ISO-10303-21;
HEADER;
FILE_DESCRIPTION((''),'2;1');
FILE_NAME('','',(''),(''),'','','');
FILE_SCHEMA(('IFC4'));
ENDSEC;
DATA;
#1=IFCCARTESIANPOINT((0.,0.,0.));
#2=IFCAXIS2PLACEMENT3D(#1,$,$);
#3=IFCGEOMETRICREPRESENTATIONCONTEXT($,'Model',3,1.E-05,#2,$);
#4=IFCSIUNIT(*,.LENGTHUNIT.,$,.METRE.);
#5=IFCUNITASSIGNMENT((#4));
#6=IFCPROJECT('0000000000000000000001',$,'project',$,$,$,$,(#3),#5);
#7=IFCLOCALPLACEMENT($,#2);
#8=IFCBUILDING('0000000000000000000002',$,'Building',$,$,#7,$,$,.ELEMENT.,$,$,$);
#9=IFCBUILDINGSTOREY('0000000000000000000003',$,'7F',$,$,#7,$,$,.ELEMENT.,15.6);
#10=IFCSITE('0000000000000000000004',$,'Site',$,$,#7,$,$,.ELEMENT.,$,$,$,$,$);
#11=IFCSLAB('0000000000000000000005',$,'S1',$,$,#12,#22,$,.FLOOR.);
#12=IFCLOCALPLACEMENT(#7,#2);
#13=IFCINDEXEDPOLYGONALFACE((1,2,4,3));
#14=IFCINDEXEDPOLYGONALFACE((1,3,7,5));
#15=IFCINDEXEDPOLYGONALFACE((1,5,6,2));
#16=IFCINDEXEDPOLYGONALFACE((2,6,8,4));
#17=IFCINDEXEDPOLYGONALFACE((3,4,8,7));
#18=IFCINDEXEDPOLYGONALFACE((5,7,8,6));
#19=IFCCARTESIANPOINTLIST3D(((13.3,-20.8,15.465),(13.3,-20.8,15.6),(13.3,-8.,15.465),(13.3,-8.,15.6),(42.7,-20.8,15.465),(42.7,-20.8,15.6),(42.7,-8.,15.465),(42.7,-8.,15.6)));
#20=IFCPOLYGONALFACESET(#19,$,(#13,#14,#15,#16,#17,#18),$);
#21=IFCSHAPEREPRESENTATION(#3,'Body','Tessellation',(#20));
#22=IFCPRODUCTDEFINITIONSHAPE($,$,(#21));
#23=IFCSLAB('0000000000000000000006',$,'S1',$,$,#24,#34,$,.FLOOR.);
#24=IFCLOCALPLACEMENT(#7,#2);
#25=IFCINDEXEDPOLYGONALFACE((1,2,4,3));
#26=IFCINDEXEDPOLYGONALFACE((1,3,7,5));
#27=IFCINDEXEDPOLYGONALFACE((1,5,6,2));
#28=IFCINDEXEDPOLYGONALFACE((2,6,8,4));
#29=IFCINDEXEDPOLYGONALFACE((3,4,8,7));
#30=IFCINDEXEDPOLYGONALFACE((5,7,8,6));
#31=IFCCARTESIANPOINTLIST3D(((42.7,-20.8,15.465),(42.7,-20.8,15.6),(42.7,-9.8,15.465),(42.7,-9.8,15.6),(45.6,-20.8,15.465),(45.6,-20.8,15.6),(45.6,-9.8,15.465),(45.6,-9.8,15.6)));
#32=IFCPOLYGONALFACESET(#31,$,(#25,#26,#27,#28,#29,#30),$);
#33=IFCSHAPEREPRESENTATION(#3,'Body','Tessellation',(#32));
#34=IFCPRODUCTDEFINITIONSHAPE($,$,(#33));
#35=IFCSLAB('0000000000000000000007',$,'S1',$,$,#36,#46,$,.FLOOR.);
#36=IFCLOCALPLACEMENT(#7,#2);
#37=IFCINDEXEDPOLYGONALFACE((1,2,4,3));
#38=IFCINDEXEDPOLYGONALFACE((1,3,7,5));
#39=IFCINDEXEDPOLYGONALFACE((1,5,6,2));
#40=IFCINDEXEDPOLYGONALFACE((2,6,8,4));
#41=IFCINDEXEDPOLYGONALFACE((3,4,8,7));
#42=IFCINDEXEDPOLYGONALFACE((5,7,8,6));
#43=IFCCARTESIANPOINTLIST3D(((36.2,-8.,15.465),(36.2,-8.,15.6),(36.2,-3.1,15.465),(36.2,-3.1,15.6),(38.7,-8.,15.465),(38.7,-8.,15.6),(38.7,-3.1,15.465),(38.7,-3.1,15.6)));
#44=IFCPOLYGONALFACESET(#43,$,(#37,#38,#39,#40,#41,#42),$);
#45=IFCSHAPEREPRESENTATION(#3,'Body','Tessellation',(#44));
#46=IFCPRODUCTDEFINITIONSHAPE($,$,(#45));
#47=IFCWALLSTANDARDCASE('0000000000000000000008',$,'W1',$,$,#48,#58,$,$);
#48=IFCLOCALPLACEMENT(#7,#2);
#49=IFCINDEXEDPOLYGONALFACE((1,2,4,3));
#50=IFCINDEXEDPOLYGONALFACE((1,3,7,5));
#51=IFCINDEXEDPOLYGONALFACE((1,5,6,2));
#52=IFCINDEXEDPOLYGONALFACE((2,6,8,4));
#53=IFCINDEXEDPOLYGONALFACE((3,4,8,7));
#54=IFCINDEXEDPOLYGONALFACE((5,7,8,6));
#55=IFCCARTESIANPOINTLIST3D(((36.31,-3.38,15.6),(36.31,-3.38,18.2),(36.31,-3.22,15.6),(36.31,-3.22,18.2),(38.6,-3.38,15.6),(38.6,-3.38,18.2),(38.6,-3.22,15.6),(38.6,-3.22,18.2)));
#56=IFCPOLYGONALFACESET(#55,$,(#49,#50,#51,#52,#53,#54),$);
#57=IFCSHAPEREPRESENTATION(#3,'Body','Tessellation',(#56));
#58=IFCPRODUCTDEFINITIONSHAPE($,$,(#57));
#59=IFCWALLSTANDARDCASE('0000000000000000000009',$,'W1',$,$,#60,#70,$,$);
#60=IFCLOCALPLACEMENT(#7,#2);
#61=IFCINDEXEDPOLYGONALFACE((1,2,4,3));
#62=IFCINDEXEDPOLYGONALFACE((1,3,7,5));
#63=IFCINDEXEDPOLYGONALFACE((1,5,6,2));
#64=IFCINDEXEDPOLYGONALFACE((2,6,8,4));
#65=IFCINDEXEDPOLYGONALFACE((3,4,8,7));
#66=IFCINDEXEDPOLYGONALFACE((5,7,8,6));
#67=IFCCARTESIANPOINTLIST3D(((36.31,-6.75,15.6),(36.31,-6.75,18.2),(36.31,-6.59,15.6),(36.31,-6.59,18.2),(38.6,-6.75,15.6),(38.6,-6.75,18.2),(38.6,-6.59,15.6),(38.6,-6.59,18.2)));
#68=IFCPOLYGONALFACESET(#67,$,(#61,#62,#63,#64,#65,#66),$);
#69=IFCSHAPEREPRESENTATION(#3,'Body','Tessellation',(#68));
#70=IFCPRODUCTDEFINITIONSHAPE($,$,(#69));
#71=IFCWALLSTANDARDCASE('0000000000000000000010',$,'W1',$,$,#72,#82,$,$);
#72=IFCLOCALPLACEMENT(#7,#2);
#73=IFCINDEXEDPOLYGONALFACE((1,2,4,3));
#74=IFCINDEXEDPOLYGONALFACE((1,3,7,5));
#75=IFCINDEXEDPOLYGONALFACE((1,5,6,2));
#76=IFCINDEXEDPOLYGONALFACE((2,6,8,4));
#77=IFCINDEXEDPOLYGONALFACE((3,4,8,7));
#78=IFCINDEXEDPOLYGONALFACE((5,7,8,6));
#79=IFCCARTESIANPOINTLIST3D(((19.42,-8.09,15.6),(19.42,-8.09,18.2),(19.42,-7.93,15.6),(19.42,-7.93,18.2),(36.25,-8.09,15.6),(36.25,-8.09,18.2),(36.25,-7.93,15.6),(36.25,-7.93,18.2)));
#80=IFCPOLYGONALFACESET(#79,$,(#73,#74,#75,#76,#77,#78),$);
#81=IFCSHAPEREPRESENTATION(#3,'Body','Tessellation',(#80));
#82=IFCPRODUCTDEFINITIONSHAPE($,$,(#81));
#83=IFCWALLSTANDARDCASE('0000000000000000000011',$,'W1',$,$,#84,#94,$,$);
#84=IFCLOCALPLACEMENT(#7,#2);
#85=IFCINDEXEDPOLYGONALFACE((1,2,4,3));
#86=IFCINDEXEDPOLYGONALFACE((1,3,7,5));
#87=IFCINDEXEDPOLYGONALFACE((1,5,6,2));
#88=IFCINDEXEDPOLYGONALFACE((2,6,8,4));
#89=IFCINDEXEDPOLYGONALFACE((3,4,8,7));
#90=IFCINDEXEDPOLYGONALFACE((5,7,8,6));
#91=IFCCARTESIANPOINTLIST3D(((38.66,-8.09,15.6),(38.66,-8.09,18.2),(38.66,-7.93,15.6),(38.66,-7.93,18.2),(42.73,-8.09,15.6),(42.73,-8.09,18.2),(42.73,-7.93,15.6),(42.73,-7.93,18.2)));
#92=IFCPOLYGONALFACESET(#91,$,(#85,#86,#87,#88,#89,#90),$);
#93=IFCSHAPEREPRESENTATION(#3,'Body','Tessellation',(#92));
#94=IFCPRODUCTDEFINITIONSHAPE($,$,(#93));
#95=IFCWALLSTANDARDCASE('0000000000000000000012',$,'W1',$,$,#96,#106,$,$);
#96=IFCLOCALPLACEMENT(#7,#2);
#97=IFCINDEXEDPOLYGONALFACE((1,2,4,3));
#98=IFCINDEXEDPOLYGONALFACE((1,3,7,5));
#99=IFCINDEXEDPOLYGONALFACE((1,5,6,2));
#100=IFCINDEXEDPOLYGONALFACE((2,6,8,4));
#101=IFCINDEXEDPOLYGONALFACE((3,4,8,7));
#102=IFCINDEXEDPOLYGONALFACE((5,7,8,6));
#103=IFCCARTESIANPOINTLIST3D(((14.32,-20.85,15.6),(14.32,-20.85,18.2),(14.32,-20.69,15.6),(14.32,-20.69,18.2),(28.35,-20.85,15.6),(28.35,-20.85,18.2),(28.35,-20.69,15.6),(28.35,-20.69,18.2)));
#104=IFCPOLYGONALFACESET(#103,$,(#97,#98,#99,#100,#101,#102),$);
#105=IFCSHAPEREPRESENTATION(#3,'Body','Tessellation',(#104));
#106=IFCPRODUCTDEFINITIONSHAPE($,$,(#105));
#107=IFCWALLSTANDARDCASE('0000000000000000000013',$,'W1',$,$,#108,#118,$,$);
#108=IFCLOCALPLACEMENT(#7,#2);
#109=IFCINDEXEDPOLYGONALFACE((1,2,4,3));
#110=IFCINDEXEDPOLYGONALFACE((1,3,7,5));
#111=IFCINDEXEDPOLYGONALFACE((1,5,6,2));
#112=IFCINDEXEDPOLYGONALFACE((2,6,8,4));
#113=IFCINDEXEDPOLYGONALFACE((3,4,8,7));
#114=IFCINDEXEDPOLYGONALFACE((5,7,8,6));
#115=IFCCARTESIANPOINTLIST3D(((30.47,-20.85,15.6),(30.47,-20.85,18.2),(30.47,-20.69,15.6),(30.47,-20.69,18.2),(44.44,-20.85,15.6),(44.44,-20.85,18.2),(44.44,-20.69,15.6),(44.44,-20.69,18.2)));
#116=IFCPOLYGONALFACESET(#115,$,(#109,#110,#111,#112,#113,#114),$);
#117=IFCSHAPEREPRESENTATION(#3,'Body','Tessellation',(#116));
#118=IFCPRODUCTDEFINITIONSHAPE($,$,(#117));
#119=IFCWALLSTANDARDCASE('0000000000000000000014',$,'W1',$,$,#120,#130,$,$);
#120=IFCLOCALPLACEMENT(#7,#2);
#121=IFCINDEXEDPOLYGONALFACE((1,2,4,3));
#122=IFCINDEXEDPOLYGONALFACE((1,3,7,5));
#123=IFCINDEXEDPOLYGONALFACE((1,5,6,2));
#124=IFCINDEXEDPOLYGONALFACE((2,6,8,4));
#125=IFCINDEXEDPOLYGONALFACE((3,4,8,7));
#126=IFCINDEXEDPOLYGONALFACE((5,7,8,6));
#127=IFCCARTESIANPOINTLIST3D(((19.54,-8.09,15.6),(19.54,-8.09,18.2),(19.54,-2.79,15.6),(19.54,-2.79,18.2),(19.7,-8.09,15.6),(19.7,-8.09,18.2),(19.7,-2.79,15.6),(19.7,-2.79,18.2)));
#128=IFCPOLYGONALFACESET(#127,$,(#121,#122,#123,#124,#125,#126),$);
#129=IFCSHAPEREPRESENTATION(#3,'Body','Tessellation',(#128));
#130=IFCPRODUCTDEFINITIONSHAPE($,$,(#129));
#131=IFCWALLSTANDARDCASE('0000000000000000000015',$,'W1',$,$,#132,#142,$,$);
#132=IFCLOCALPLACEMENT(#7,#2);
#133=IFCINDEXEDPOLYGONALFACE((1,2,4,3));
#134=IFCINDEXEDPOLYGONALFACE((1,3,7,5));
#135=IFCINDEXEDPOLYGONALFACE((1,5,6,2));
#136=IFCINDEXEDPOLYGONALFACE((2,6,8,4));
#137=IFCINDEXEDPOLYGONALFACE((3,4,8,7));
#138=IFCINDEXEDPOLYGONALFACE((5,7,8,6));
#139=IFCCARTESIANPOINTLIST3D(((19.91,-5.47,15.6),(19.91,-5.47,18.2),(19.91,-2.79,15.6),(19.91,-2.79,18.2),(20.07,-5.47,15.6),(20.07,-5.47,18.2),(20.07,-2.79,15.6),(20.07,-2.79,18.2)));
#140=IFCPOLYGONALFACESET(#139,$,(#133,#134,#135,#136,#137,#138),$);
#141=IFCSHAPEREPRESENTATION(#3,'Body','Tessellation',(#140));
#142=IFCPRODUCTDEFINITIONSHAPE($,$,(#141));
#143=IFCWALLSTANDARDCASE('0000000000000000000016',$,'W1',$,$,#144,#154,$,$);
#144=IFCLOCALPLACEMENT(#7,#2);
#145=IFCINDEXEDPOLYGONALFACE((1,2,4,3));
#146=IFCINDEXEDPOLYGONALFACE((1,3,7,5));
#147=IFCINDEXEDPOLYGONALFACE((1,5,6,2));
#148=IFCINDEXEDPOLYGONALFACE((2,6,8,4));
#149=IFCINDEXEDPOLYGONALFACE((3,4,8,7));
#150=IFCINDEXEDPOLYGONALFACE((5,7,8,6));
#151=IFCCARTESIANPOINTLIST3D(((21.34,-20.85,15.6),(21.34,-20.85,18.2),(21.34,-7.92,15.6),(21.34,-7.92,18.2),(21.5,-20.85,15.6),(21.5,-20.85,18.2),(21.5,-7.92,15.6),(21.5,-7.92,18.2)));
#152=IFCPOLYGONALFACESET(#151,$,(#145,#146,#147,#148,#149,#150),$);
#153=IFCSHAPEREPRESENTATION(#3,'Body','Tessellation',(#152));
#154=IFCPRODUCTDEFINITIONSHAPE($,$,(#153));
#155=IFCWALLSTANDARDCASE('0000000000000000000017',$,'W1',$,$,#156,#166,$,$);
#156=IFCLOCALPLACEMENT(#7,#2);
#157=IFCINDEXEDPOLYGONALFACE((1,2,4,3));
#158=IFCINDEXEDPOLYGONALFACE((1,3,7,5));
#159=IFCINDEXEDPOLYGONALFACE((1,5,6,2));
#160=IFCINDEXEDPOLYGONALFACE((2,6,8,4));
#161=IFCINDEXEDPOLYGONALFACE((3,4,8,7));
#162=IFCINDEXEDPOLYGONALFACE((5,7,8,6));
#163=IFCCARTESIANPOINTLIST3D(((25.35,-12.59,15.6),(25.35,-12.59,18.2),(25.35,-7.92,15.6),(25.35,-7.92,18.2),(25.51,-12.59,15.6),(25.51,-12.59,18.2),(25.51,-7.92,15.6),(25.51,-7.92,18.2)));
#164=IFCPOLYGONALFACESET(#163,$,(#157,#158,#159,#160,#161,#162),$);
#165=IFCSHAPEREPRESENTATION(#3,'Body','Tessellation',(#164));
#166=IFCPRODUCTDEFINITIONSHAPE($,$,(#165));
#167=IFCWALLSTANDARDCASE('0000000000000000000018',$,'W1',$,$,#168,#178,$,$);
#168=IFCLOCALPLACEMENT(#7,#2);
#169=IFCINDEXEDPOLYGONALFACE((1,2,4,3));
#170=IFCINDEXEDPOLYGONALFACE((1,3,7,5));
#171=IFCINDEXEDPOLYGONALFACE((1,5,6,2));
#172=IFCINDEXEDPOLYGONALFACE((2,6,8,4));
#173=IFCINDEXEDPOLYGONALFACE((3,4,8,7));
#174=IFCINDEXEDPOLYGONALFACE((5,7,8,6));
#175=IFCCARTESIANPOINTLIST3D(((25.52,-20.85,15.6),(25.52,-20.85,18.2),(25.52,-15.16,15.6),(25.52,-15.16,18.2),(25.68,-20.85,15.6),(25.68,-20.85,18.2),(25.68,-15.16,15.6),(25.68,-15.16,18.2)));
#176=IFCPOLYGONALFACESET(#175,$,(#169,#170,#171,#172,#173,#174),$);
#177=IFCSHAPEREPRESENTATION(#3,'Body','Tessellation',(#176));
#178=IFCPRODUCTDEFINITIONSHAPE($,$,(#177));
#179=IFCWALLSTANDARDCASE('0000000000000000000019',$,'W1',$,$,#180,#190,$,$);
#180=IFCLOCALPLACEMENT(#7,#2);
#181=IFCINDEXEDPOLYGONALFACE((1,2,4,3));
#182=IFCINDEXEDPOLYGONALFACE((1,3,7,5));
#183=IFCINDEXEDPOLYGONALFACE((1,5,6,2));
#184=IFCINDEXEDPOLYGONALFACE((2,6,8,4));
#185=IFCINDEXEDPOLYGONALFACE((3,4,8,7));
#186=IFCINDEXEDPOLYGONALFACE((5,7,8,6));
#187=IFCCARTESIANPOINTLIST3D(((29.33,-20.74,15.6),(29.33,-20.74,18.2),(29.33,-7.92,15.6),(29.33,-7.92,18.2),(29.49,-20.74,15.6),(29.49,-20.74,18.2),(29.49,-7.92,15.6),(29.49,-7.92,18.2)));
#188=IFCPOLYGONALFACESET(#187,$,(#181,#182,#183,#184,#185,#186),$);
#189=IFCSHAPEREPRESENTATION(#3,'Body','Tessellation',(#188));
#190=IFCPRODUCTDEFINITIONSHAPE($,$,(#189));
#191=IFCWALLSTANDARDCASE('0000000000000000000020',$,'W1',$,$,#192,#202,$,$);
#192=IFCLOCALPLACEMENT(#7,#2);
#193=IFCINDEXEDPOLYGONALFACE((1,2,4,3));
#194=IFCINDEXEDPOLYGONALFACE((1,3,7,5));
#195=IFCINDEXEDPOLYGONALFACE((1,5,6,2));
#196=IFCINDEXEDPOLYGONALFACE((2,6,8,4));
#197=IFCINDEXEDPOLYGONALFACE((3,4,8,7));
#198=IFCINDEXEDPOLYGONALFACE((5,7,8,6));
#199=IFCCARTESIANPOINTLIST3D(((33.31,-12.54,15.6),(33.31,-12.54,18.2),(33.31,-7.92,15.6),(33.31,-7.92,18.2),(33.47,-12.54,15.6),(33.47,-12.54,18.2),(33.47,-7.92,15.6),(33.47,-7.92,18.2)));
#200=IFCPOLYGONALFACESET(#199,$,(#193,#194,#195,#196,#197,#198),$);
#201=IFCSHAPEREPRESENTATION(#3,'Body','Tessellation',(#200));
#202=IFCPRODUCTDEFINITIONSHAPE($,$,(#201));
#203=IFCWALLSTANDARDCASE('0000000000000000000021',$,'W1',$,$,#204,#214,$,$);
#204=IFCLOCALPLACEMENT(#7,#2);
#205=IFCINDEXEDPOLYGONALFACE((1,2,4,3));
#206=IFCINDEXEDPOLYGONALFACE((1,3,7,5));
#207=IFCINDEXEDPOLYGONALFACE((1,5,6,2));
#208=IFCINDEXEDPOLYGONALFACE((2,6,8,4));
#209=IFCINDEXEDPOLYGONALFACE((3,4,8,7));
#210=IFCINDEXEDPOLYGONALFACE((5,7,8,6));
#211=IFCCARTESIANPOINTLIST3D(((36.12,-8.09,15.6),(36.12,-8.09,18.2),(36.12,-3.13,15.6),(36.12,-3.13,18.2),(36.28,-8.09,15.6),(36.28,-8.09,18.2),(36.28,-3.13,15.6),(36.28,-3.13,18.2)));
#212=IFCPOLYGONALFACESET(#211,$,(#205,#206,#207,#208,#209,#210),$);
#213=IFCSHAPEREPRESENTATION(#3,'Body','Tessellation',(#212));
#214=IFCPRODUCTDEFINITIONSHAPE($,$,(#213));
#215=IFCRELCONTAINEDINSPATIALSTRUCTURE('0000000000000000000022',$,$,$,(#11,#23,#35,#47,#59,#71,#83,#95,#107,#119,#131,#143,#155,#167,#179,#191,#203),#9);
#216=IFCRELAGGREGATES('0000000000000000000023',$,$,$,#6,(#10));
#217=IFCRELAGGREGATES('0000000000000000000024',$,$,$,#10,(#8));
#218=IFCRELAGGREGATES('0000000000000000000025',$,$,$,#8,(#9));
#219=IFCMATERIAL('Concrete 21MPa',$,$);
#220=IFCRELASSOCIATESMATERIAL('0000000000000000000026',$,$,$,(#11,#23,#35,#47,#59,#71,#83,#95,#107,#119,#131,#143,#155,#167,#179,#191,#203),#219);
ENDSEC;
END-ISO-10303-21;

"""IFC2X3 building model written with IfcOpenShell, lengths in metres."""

from ifc_helpers import new_model, si_unit, frame, origin, origin_2d, place, context, project, spatial, rectangle, extrude, material, element, save


model = new_model("IFC2X3")

# Units and contexts
model_context = context("Model", 3, precision=1e-05, world=origin())
ifc_project = project(units=[si_unit("LENGTHUNIT", "METRE")], contexts=[model_context])

# Site, building, storey
placement = place(None, origin())
site = spatial("IfcSite", under=ifc_project, at=placement, Name="Site", CompositionType="ELEMENT")
building = spatial("IfcBuilding", under=site, at=placement, Name="Building", CompositionType="ELEMENT")
storey = spatial("IfcBuildingStorey", under=building, at=placement, Name="7F", CompositionType="ELEMENT", Elevation=15.6)

# Slabs
ifc_material_1 = material(Name="Concrete 21MPa")
slab_1_placement = place(None, frame((28.0, -14.4, 15.465)))
element("IfcSlab", 1, at=slab_1_placement, inside=storey, material=ifc_material_1, Name="S1", PredefinedType="FLOOR", context=model_context, shape_type="SweptSolid", body=[
    extrude(rectangle(XDim=29.4, YDim=12.8, at=origin_2d()), origin(), (0.0, 0.0, 1.0), 0.135),
])
slab_2_placement = place(None, frame((44.15, -15.3, 15.465)))
element("IfcSlab", 2, at=slab_2_placement, inside=storey, material=ifc_material_1, Name="S1", PredefinedType="FLOOR", context=model_context, shape_type="SweptSolid", body=[
    extrude(rectangle(XDim=2.9, YDim=11.0, at=origin_2d()), origin(), (0.0, 0.0, 1.0), 0.135),
])
slab_3_placement = place(None, frame((37.45, -5.55, 15.465)))
element("IfcSlab", 3, at=slab_3_placement, inside=storey, material=ifc_material_1, Name="S1", PredefinedType="FLOOR", context=model_context, shape_type="SweptSolid", body=[
    extrude(rectangle(XDim=2.5, YDim=4.9, at=origin_2d()), origin(), (0.0, 0.0, 1.0), 0.135),
])

# Walls
for number, where, name in (
    (4, (37.455, -3.3, 15.6), "W1"),
    (5, (37.455, -6.67, 15.6), "W1"),
):
    element("IfcWallStandardCase", number, at=place(None, frame(where)), inside=storey, material=ifc_material_1, Name=name, context=model_context, shape_type="SweptSolid", body=[
        extrude(rectangle(XDim=2.29, YDim=0.16, at=origin_2d()), origin(), (0.0, 0.0, 1.0), 2.6),
    ])
wall_1_placement = place(None, frame((27.835, -8.01, 15.6)))
element("IfcWallStandardCase", 6, at=wall_1_placement, inside=storey, material=ifc_material_1, Name="W1", context=model_context, shape_type="SweptSolid", body=[
    extrude(rectangle(XDim=16.83, YDim=0.16, at=origin_2d()), origin(), (0.0, 0.0, 1.0), 2.6),
])
wall_2_placement = place(None, frame((40.695, -8.01, 15.6)))
element("IfcWallStandardCase", 7, at=wall_2_placement, inside=storey, material=ifc_material_1, Name="W1", context=model_context, shape_type="SweptSolid", body=[
    extrude(rectangle(XDim=4.07, YDim=0.16, at=origin_2d()), origin(), (0.0, 0.0, 1.0), 2.6),
])
wall_3_placement = place(None, frame((21.335, -20.77, 15.6)))
element("IfcWallStandardCase", 8, at=wall_3_placement, inside=storey, material=ifc_material_1, Name="W1", context=model_context, shape_type="SweptSolid", body=[
    extrude(rectangle(XDim=14.03, YDim=0.16, at=origin_2d()), origin(), (0.0, 0.0, 1.0), 2.6),
])
wall_4_placement = place(None, frame((37.455, -20.77, 15.6)))
element("IfcWallStandardCase", 9, at=wall_4_placement, inside=storey, material=ifc_material_1, Name="W1", context=model_context, shape_type="SweptSolid", body=[
    extrude(rectangle(XDim=13.97, YDim=0.16, at=origin_2d()), origin(), (0.0, 0.0, 1.0), 2.6),
])
wall_5_placement = place(None, frame((19.62, -5.44, 15.6)))
element("IfcWallStandardCase", 10, at=wall_5_placement, inside=storey, material=ifc_material_1, Name="W1", context=model_context, shape_type="SweptSolid", body=[
    extrude(rectangle(XDim=0.16, YDim=5.3, at=origin_2d()), origin(), (0.0, 0.0, 1.0), 2.6),
])
wall_6_placement = place(None, frame((19.99, -4.13, 15.6)))
element("IfcWallStandardCase", 11, at=wall_6_placement, inside=storey, material=ifc_material_1, Name="W1", context=model_context, shape_type="SweptSolid", body=[
    extrude(rectangle(XDim=0.16, YDim=2.68, at=origin_2d()), origin(), (0.0, 0.0, 1.0), 2.6),
])
wall_7_placement = place(None, frame((21.42, -14.385, 15.6)))
element("IfcWallStandardCase", 12, at=wall_7_placement, inside=storey, material=ifc_material_1, Name="W1", context=model_context, shape_type="SweptSolid", body=[
    extrude(rectangle(XDim=0.16, YDim=12.93, at=origin_2d()), origin(), (0.0, 0.0, 1.0), 2.6),
])
wall_8_placement = place(None, frame((25.43, -10.255, 15.6)))
element("IfcWallStandardCase", 13, at=wall_8_placement, inside=storey, material=ifc_material_1, Name="W1", context=model_context, shape_type="SweptSolid", body=[
    extrude(rectangle(XDim=0.16, YDim=4.67, at=origin_2d()), origin(), (0.0, 0.0, 1.0), 2.6),
])
wall_9_placement = place(None, frame((25.6, -18.005, 15.6)))
element("IfcWallStandardCase", 14, at=wall_9_placement, inside=storey, material=ifc_material_1, Name="W1", context=model_context, shape_type="SweptSolid", body=[
    extrude(rectangle(XDim=0.16, YDim=5.69, at=origin_2d()), origin(), (0.0, 0.0, 1.0), 2.6),
])
wall_10_placement = place(None, frame((29.41, -14.33, 15.6)))
element("IfcWallStandardCase", 15, at=wall_10_placement, inside=storey, material=ifc_material_1, Name="W1", context=model_context, shape_type="SweptSolid", body=[
    extrude(rectangle(XDim=0.16, YDim=12.82, at=origin_2d()), origin(), (0.0, 0.0, 1.0), 2.6),
])
wall_11_placement = place(None, frame((33.39, -10.23, 15.6)))
element("IfcWallStandardCase", 16, at=wall_11_placement, inside=storey, material=ifc_material_1, Name="W1", context=model_context, shape_type="SweptSolid", body=[
    extrude(rectangle(XDim=0.16, YDim=4.62, at=origin_2d()), origin(), (0.0, 0.0, 1.0), 2.6),
])
wall_12_placement = place(None, frame((36.2, -5.61, 15.6)))
element("IfcWallStandardCase", 17, at=wall_12_placement, inside=storey, material=ifc_material_1, Name="W1", context=model_context, shape_type="SweptSolid", body=[
    extrude(rectangle(XDim=0.16, YDim=4.96, at=origin_2d()), origin(), (0.0, 0.0, 1.0), 2.6),
])

save(model, "model.ifc")
